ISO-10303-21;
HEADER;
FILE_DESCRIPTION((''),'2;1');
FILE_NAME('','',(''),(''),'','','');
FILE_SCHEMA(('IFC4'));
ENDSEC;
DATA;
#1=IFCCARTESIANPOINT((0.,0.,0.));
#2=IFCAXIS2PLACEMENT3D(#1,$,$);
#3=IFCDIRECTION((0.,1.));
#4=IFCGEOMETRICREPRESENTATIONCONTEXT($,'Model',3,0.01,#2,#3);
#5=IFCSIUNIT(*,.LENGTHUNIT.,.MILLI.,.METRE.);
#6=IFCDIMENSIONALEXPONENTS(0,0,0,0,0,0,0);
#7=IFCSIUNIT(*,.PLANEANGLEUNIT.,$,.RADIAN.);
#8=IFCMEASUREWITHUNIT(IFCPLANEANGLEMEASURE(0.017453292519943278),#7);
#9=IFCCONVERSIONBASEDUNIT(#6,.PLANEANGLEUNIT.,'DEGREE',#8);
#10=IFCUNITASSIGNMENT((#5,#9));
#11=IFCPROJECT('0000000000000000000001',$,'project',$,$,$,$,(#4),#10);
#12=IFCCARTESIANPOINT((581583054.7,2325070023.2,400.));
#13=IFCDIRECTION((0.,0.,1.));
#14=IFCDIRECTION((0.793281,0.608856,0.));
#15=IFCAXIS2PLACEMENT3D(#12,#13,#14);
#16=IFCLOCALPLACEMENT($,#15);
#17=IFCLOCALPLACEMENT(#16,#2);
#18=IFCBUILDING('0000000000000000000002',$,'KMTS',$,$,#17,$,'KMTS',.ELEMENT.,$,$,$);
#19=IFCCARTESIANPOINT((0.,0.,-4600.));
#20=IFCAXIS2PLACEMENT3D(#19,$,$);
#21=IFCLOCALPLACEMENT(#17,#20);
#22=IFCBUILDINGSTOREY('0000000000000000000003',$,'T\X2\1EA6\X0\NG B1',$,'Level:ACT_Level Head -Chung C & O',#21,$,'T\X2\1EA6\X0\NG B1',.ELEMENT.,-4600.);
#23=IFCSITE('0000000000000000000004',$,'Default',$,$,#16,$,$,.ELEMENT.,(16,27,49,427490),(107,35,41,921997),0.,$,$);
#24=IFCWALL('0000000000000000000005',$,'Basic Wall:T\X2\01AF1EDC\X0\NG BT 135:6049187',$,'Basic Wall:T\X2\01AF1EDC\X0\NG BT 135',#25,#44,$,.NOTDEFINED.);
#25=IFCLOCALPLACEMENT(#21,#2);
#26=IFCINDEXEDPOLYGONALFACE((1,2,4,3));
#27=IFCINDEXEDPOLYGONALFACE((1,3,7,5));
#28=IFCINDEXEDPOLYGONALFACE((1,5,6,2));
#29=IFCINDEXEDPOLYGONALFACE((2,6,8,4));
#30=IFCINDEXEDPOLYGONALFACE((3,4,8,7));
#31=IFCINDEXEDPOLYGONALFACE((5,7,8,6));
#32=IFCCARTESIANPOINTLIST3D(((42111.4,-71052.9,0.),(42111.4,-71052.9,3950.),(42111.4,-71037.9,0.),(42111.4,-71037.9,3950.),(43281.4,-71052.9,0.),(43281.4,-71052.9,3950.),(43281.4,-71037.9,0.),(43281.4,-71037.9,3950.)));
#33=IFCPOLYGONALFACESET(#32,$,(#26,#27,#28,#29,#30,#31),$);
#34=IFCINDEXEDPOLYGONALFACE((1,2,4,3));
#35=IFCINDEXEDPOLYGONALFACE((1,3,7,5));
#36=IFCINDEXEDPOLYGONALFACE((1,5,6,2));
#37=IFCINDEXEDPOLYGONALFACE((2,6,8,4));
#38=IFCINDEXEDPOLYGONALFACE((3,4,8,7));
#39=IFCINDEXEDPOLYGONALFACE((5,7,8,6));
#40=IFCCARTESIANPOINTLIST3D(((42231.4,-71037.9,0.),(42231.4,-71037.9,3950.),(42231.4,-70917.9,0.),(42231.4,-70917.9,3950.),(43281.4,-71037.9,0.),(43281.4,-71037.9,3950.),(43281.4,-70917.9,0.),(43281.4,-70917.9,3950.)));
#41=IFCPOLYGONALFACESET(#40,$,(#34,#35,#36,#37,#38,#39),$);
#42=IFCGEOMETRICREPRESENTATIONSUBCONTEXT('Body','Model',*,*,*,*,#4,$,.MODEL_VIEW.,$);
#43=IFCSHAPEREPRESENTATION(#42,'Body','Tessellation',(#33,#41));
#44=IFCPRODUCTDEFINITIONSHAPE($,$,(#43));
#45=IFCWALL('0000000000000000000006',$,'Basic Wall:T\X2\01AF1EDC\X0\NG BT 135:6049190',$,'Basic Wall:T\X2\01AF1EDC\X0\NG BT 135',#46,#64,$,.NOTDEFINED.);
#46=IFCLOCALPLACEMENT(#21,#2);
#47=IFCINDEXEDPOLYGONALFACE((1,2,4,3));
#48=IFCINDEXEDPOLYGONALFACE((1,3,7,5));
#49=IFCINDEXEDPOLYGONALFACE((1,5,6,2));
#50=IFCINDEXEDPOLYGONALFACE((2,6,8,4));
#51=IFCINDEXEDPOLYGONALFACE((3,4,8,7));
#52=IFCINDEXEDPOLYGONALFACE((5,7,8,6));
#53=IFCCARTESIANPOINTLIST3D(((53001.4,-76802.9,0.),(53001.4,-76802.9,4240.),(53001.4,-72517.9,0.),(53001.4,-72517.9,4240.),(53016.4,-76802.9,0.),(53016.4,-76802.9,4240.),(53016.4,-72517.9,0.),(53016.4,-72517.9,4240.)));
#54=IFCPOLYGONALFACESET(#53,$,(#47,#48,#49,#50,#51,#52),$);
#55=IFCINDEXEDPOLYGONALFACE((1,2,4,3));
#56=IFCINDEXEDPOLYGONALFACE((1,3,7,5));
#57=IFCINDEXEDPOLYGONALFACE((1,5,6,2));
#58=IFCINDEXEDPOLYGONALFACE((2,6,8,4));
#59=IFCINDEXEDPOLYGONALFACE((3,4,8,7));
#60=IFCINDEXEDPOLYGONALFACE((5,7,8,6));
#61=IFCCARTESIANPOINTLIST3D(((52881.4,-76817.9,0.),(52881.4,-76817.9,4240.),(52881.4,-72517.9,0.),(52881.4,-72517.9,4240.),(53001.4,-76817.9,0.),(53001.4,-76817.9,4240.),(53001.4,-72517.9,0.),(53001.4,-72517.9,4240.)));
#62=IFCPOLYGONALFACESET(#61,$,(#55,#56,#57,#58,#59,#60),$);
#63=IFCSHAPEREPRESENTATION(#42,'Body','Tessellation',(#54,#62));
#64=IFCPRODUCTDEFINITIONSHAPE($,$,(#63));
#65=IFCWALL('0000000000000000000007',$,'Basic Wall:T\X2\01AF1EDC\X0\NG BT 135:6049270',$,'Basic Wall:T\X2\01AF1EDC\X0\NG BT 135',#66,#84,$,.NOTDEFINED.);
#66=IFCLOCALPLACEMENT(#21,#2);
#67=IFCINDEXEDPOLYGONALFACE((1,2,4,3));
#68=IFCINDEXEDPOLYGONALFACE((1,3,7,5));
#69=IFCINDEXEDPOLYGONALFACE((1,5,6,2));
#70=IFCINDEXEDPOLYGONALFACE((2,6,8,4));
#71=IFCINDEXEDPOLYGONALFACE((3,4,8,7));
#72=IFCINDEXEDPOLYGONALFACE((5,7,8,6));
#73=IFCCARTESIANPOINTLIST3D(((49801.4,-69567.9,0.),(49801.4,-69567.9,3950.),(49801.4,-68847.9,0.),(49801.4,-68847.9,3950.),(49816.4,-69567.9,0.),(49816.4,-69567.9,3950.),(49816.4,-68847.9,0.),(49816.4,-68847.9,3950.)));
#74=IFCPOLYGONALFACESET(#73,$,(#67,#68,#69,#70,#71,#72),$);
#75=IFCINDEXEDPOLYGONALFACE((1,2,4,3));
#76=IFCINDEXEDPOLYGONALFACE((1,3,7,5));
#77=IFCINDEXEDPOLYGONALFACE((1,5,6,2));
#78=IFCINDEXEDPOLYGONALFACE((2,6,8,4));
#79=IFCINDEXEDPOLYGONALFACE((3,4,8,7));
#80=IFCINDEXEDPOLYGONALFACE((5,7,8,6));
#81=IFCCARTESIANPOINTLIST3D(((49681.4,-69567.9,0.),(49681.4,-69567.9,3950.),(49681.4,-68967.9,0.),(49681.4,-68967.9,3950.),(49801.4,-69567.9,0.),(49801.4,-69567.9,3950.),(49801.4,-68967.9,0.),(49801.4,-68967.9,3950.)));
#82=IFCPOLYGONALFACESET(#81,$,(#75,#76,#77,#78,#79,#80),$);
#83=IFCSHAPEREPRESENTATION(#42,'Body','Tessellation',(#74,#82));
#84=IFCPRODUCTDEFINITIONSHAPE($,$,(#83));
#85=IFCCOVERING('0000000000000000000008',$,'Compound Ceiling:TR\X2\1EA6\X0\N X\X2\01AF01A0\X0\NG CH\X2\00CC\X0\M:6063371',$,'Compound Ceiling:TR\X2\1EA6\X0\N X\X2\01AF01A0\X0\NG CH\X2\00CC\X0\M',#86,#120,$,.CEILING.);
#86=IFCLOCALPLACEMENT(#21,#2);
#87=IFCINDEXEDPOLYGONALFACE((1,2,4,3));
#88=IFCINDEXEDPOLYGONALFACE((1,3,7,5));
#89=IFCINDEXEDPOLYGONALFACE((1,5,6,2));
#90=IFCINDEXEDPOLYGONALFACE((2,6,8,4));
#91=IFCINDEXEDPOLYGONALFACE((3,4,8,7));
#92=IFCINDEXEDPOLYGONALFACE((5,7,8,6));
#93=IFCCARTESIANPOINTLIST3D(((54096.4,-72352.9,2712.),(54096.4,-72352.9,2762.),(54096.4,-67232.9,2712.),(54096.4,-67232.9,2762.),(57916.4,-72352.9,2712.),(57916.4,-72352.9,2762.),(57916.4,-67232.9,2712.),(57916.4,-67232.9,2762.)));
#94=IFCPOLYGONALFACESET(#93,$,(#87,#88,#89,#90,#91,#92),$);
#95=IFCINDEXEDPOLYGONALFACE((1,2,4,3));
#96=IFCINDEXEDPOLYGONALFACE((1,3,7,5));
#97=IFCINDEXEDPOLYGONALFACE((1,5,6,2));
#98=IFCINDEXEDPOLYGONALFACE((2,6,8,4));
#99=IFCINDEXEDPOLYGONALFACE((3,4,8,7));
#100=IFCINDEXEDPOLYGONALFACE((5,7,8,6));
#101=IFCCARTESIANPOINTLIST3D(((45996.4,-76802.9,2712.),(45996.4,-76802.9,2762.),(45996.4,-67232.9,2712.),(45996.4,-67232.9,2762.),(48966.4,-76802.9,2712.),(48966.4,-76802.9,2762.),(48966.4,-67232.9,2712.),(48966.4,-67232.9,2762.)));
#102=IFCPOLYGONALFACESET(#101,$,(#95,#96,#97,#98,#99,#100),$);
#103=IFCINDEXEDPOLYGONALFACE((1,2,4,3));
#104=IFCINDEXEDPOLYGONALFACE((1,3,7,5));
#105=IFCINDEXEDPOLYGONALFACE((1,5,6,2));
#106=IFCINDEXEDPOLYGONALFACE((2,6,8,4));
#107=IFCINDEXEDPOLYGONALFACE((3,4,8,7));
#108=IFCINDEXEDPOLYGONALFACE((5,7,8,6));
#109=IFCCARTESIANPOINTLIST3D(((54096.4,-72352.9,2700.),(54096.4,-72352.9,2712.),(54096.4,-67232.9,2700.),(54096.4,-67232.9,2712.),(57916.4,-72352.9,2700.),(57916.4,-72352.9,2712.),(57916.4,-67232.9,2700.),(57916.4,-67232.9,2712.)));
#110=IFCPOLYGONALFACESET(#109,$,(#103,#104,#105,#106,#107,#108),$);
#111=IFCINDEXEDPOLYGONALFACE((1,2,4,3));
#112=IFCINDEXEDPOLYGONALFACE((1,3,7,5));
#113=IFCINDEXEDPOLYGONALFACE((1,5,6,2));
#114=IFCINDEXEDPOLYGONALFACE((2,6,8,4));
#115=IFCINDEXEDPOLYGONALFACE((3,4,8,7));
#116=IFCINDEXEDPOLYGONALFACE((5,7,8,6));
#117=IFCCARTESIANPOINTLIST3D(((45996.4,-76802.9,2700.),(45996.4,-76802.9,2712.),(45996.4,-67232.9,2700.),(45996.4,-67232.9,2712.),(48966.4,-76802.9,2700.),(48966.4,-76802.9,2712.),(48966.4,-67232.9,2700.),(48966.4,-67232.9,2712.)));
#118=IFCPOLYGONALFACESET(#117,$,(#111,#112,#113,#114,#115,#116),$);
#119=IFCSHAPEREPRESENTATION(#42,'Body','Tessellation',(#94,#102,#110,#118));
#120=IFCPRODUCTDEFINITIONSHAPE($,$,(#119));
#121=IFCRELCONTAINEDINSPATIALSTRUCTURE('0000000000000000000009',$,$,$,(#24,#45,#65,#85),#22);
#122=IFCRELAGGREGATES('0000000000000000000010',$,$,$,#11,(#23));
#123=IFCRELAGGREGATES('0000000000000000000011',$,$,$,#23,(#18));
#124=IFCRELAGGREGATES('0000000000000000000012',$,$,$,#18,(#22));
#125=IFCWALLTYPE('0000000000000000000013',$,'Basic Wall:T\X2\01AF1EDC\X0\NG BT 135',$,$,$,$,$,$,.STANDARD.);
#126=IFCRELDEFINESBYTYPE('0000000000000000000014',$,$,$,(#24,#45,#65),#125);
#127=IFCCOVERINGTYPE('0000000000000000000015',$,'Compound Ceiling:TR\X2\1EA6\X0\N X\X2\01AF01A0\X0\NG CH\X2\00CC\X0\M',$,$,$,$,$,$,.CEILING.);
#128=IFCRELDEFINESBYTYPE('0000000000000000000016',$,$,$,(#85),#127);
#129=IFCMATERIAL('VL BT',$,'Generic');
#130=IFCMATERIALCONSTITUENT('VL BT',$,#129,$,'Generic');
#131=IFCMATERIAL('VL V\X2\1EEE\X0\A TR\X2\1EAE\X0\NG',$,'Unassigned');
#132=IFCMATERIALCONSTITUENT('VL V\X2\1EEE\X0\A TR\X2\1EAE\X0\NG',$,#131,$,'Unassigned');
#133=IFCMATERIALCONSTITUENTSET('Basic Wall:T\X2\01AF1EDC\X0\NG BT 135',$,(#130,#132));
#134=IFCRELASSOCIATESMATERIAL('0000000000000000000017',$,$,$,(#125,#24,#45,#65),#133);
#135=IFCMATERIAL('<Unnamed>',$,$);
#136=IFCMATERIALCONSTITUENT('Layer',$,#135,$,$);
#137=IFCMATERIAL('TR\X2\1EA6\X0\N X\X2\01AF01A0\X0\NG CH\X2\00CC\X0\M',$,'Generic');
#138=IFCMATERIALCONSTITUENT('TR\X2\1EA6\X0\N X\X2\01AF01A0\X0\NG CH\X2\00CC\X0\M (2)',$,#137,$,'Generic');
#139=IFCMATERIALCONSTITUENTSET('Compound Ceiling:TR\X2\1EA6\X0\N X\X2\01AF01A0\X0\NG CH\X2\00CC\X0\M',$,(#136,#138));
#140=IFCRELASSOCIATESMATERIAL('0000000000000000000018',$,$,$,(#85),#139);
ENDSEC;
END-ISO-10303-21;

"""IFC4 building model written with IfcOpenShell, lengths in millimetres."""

from ifc_helpers import new_model, entity, si_unit, converted_unit, direction, frame, origin, place, context, subcontext, project, spatial, indexed_curve, outline, extrude, material, constituent, constituent_set, type_object, element, save


model = new_model("IFC4")

# Units and contexts
model_context = context("Model", 3, precision=0.01, world=origin(), true_north=direction((0.0, 1.0)))
body_context = subcontext(model_context, "Body", "Model", "MODEL_VIEW")
ifc_project = project(units=[si_unit("LENGTHUNIT", "METRE", prefix="MILLI"), converted_unit("PLANEANGLEUNIT", "DEGREE", entity("IfcPlaneAngleMeasure", 0.017453292519943278), si_unit("PLANEANGLEUNIT", "RADIAN"), dimensions=[0, 0, 0, 0, 0, 0, 0])], contexts=[model_context])

# Site, building, storey
site_placement = place(None, frame((581583054.7, 2325070023.2, 400.0), z_axis=(0.0, 0.0, 1.0), x_axis=(0.793281, 0.608856, 0.0)))
site = spatial("IfcSite", under=ifc_project, at=site_placement, Name="Default", CompositionType="ELEMENT", RefLatitude=(16, 27, 49, 427490), RefLongitude=(107, 35, 41, 921997), RefElevation=0.0)
building_placement = place(site_placement, origin())
building = spatial("IfcBuilding", under=site, at=building_placement, Name="KMTS", LongName="KMTS", CompositionType="ELEMENT")
storey_placement = place(building_placement, frame((0.0, 0.0, -4600.0)))
storey = spatial("IfcBuildingStorey", under=building, at=storey_placement, Name="TẦNG B1", ObjectType="Level:ACT_Level Head -Chung C & O", LongName="TẦNG B1", CompositionType="ELEMENT", Elevation=-4600.0)

# Shared definitions
ifc_material_1 = material(Name="VL VỮA TRẮNG", Category="Unassigned")
ifc_material_2 = material(Name="VL BT", Category="Generic")

# Walls
ifc_constituent_1 = constituent(ifc_material_2, Name="VL BT", Category="Generic")
ifc_constituent_2 = constituent(ifc_material_1, Name="VL VỮA TRẮNG", Category="Unassigned")
ifc_constituent_set_1 = constituent_set(constituents=[ifc_constituent_1, ifc_constituent_2], Name="Basic Wall:TƯỜNG BT 135")
wall_type_1 = type_object("IfcWallType", Name="Basic Wall:TƯỜNG BT 135", PredefinedType="STANDARD", material=ifc_constituent_set_1)
wall_1_placement = place(storey_placement, frame((42231.4, -70985.4, 0.0)))
element("IfcWall", 1, at=wall_1_placement, inside=storey, type_object=wall_type_1, material=ifc_constituent_set_1, Name="Basic Wall:TƯỜNG BT 135:6049187", ObjectType="Basic Wall:TƯỜNG BT 135", PredefinedType="NOTDEFINED", context=body_context, shape_type="SweptSolid", body=[
    extrude(outline(indexed_curve([(-7.5, -585.0), (7.5, -585.0), (7.5, 585.0), (-7.5, 585.0), (-7.5, -585.0)], self_intersect=False)), frame((465.0, -60.0, 0.0), z_axis=(0.0, 0.0, 1.0), x_axis=(0.0, 1.0, 0.0)), (0.0, 0.0, 1.0), 3950.0),
    extrude(outline(indexed_curve([(-60.0, -525.0), (60.0, -525.0), (60.0, 525.0), (-60.0, 525.0), (-60.0, -525.0)], self_intersect=False)), frame((525.0, 7.5, 0.0), z_axis=(0.0, 0.0, 1.0), x_axis=(0.0, -1.0, 0.0)), (0.0, 0.0, 1.0), 3950.0),
])
wall_2_placement = place(storey_placement, frame((52948.9, -76802.9, 0.0), z_axis=(0.0, 0.0, 1.0), x_axis=(0.0, 1.0, 0.0)))
element("IfcWall", 2, at=wall_2_placement, inside=storey, type_object=wall_type_1, material=ifc_constituent_set_1, Name="Basic Wall:TƯỜNG BT 135:6049190", ObjectType="Basic Wall:TƯỜNG BT 135", PredefinedType="NOTDEFINED", context=body_context, shape_type="SweptSolid", body=[
    extrude(outline(indexed_curve([(-7.5, -2142.5), (7.5, -2142.5), (7.5, 2142.5), (-7.5, 2142.5), (-7.5, -2142.5)], self_intersect=False)), frame((2142.5, -60.0, 0.0), z_axis=(0.0, 0.0, 1.0), x_axis=(0.0, 1.0, 0.0)), (0.0, 0.0, 1.0), 4240.0),
    extrude(outline(indexed_curve([(-60.0, -2150.0), (60.0, -2150.0), (60.0, 2150.0), (-60.0, 2150.0), (-60.0, -2150.0)], self_intersect=False)), frame((2135.0, 7.5, 0.0), z_axis=(0.0, 0.0, 1.0), x_axis=(0.0, -1.0, 0.0)), (0.0, 0.0, 1.0), 4240.0),
])
wall_3_placement = place(storey_placement, frame((49748.9, -68967.9, 0.0), z_axis=(0.0, 0.0, 1.0), x_axis=(0.0, -1.0, 0.0)))
element("IfcWall", 3, at=wall_3_placement, inside=storey, type_object=wall_type_1, material=ifc_constituent_set_1, Name="Basic Wall:TƯỜNG BT 135:6049270", ObjectType="Basic Wall:TƯỜNG BT 135", PredefinedType="NOTDEFINED", context=body_context, shape_type="SweptSolid", body=[
    extrude(outline(indexed_curve([(-7.5, -360.0), (7.5, -360.0), (7.5, 360.0), (-7.5, 360.0), (-7.5, -360.0)], self_intersect=False)), frame((240.0, 60.0, 0.0), z_axis=(0.0, 0.0, 1.0), x_axis=(0.0, -1.0, 0.0)), (0.0, 0.0, 1.0), 3950.0),
    extrude(outline(indexed_curve([(-60.0, -300.0), (60.0, -300.0), (60.0, 300.0), (-60.0, 300.0), (-60.0, -300.0)], self_intersect=False)), frame((300.0, -7.5, 0.0), z_axis=(0.0, 0.0, 1.0), x_axis=(0.0, 1.0, 0.0)), (0.0, 0.0, 1.0), 3950.0),
])

# Covering
ifc_material_3 = material(Name="<Unnamed>")
ifc_constituent_3 = constituent(ifc_material_3, Name="Layer")
ifc_material_4 = material(Name="TRẦN XƯƠNG CHÌM", Category="Generic")
ifc_constituent_4 = constituent(ifc_material_4, Name="TRẦN XƯƠNG CHÌM (2)", Category="Generic")
ifc_constituent_set_2 = constituent_set(constituents=[ifc_constituent_3, ifc_constituent_4], Name="Compound Ceiling:TRẦN XƯƠNG CHÌM")
covering_type = type_object("IfcCoveringType", Name="Compound Ceiling:TRẦN XƯƠNG CHÌM", PredefinedType="CEILING")
covering_placement = place(storey_placement, frame((45996.4, -76802.9, 2700.0)))
element("IfcCovering", 4, at=covering_placement, inside=storey, type_object=covering_type, material=ifc_constituent_set_2, Name="Compound Ceiling:TRẦN XƯƠNG CHÌM:6063371", ObjectType="Compound Ceiling:TRẦN XƯƠNG CHÌM", PredefinedType="CEILING", context=body_context, shape_type="SweptSolid", body=[
    extrude(outline(indexed_curve([(-2560.0, -1910.0), (2560.0, -1910.0), (2560.0, 1910.0), (-2560.0, 1910.0), (-2560.0, -1910.0)], self_intersect=False)), frame((10010.0, 7010.0, 12.0), z_axis=(0.0, 0.0, 1.0), x_axis=(0.0, -1.0, 0.0)), (0.0, 0.0, 1.0), 50.0),
    extrude(outline(indexed_curve([(-1485.0, -4785.0), (1485.0, -4785.0), (1485.0, 4785.0), (-1485.0, 4785.0), (-1485.0, -4785.0)], self_intersect=False)), frame((1485.0, 4785.0, 12.0)), (0.0, 0.0, 1.0), 50.0),
    extrude(outline(indexed_curve([(-1910.0, -2560.0), (1910.0, -2560.0), (1910.0, 2560.0), (-1910.0, 2560.0), (-1910.0, -2560.0)], self_intersect=False)), frame((10010.0, 7010.0, 0.0), z_axis=(0.0, 0.0, 1.0), x_axis=(-1.0, 0.0, 0.0)), (0.0, 0.0, 1.0), 12.0),
    extrude(outline(indexed_curve([(-4785.0, -1485.0), (4785.0, -1485.0), (4785.0, 1485.0), (-4785.0, 1485.0), (-4785.0, -1485.0)], self_intersect=False)), frame((1485.0, 4785.0, 0.0), z_axis=(0.0, 0.0, 1.0), x_axis=(0.0, -1.0, 0.0)), (0.0, 0.0, 1.0), 12.0),
])

save(model, "model.ifc")
